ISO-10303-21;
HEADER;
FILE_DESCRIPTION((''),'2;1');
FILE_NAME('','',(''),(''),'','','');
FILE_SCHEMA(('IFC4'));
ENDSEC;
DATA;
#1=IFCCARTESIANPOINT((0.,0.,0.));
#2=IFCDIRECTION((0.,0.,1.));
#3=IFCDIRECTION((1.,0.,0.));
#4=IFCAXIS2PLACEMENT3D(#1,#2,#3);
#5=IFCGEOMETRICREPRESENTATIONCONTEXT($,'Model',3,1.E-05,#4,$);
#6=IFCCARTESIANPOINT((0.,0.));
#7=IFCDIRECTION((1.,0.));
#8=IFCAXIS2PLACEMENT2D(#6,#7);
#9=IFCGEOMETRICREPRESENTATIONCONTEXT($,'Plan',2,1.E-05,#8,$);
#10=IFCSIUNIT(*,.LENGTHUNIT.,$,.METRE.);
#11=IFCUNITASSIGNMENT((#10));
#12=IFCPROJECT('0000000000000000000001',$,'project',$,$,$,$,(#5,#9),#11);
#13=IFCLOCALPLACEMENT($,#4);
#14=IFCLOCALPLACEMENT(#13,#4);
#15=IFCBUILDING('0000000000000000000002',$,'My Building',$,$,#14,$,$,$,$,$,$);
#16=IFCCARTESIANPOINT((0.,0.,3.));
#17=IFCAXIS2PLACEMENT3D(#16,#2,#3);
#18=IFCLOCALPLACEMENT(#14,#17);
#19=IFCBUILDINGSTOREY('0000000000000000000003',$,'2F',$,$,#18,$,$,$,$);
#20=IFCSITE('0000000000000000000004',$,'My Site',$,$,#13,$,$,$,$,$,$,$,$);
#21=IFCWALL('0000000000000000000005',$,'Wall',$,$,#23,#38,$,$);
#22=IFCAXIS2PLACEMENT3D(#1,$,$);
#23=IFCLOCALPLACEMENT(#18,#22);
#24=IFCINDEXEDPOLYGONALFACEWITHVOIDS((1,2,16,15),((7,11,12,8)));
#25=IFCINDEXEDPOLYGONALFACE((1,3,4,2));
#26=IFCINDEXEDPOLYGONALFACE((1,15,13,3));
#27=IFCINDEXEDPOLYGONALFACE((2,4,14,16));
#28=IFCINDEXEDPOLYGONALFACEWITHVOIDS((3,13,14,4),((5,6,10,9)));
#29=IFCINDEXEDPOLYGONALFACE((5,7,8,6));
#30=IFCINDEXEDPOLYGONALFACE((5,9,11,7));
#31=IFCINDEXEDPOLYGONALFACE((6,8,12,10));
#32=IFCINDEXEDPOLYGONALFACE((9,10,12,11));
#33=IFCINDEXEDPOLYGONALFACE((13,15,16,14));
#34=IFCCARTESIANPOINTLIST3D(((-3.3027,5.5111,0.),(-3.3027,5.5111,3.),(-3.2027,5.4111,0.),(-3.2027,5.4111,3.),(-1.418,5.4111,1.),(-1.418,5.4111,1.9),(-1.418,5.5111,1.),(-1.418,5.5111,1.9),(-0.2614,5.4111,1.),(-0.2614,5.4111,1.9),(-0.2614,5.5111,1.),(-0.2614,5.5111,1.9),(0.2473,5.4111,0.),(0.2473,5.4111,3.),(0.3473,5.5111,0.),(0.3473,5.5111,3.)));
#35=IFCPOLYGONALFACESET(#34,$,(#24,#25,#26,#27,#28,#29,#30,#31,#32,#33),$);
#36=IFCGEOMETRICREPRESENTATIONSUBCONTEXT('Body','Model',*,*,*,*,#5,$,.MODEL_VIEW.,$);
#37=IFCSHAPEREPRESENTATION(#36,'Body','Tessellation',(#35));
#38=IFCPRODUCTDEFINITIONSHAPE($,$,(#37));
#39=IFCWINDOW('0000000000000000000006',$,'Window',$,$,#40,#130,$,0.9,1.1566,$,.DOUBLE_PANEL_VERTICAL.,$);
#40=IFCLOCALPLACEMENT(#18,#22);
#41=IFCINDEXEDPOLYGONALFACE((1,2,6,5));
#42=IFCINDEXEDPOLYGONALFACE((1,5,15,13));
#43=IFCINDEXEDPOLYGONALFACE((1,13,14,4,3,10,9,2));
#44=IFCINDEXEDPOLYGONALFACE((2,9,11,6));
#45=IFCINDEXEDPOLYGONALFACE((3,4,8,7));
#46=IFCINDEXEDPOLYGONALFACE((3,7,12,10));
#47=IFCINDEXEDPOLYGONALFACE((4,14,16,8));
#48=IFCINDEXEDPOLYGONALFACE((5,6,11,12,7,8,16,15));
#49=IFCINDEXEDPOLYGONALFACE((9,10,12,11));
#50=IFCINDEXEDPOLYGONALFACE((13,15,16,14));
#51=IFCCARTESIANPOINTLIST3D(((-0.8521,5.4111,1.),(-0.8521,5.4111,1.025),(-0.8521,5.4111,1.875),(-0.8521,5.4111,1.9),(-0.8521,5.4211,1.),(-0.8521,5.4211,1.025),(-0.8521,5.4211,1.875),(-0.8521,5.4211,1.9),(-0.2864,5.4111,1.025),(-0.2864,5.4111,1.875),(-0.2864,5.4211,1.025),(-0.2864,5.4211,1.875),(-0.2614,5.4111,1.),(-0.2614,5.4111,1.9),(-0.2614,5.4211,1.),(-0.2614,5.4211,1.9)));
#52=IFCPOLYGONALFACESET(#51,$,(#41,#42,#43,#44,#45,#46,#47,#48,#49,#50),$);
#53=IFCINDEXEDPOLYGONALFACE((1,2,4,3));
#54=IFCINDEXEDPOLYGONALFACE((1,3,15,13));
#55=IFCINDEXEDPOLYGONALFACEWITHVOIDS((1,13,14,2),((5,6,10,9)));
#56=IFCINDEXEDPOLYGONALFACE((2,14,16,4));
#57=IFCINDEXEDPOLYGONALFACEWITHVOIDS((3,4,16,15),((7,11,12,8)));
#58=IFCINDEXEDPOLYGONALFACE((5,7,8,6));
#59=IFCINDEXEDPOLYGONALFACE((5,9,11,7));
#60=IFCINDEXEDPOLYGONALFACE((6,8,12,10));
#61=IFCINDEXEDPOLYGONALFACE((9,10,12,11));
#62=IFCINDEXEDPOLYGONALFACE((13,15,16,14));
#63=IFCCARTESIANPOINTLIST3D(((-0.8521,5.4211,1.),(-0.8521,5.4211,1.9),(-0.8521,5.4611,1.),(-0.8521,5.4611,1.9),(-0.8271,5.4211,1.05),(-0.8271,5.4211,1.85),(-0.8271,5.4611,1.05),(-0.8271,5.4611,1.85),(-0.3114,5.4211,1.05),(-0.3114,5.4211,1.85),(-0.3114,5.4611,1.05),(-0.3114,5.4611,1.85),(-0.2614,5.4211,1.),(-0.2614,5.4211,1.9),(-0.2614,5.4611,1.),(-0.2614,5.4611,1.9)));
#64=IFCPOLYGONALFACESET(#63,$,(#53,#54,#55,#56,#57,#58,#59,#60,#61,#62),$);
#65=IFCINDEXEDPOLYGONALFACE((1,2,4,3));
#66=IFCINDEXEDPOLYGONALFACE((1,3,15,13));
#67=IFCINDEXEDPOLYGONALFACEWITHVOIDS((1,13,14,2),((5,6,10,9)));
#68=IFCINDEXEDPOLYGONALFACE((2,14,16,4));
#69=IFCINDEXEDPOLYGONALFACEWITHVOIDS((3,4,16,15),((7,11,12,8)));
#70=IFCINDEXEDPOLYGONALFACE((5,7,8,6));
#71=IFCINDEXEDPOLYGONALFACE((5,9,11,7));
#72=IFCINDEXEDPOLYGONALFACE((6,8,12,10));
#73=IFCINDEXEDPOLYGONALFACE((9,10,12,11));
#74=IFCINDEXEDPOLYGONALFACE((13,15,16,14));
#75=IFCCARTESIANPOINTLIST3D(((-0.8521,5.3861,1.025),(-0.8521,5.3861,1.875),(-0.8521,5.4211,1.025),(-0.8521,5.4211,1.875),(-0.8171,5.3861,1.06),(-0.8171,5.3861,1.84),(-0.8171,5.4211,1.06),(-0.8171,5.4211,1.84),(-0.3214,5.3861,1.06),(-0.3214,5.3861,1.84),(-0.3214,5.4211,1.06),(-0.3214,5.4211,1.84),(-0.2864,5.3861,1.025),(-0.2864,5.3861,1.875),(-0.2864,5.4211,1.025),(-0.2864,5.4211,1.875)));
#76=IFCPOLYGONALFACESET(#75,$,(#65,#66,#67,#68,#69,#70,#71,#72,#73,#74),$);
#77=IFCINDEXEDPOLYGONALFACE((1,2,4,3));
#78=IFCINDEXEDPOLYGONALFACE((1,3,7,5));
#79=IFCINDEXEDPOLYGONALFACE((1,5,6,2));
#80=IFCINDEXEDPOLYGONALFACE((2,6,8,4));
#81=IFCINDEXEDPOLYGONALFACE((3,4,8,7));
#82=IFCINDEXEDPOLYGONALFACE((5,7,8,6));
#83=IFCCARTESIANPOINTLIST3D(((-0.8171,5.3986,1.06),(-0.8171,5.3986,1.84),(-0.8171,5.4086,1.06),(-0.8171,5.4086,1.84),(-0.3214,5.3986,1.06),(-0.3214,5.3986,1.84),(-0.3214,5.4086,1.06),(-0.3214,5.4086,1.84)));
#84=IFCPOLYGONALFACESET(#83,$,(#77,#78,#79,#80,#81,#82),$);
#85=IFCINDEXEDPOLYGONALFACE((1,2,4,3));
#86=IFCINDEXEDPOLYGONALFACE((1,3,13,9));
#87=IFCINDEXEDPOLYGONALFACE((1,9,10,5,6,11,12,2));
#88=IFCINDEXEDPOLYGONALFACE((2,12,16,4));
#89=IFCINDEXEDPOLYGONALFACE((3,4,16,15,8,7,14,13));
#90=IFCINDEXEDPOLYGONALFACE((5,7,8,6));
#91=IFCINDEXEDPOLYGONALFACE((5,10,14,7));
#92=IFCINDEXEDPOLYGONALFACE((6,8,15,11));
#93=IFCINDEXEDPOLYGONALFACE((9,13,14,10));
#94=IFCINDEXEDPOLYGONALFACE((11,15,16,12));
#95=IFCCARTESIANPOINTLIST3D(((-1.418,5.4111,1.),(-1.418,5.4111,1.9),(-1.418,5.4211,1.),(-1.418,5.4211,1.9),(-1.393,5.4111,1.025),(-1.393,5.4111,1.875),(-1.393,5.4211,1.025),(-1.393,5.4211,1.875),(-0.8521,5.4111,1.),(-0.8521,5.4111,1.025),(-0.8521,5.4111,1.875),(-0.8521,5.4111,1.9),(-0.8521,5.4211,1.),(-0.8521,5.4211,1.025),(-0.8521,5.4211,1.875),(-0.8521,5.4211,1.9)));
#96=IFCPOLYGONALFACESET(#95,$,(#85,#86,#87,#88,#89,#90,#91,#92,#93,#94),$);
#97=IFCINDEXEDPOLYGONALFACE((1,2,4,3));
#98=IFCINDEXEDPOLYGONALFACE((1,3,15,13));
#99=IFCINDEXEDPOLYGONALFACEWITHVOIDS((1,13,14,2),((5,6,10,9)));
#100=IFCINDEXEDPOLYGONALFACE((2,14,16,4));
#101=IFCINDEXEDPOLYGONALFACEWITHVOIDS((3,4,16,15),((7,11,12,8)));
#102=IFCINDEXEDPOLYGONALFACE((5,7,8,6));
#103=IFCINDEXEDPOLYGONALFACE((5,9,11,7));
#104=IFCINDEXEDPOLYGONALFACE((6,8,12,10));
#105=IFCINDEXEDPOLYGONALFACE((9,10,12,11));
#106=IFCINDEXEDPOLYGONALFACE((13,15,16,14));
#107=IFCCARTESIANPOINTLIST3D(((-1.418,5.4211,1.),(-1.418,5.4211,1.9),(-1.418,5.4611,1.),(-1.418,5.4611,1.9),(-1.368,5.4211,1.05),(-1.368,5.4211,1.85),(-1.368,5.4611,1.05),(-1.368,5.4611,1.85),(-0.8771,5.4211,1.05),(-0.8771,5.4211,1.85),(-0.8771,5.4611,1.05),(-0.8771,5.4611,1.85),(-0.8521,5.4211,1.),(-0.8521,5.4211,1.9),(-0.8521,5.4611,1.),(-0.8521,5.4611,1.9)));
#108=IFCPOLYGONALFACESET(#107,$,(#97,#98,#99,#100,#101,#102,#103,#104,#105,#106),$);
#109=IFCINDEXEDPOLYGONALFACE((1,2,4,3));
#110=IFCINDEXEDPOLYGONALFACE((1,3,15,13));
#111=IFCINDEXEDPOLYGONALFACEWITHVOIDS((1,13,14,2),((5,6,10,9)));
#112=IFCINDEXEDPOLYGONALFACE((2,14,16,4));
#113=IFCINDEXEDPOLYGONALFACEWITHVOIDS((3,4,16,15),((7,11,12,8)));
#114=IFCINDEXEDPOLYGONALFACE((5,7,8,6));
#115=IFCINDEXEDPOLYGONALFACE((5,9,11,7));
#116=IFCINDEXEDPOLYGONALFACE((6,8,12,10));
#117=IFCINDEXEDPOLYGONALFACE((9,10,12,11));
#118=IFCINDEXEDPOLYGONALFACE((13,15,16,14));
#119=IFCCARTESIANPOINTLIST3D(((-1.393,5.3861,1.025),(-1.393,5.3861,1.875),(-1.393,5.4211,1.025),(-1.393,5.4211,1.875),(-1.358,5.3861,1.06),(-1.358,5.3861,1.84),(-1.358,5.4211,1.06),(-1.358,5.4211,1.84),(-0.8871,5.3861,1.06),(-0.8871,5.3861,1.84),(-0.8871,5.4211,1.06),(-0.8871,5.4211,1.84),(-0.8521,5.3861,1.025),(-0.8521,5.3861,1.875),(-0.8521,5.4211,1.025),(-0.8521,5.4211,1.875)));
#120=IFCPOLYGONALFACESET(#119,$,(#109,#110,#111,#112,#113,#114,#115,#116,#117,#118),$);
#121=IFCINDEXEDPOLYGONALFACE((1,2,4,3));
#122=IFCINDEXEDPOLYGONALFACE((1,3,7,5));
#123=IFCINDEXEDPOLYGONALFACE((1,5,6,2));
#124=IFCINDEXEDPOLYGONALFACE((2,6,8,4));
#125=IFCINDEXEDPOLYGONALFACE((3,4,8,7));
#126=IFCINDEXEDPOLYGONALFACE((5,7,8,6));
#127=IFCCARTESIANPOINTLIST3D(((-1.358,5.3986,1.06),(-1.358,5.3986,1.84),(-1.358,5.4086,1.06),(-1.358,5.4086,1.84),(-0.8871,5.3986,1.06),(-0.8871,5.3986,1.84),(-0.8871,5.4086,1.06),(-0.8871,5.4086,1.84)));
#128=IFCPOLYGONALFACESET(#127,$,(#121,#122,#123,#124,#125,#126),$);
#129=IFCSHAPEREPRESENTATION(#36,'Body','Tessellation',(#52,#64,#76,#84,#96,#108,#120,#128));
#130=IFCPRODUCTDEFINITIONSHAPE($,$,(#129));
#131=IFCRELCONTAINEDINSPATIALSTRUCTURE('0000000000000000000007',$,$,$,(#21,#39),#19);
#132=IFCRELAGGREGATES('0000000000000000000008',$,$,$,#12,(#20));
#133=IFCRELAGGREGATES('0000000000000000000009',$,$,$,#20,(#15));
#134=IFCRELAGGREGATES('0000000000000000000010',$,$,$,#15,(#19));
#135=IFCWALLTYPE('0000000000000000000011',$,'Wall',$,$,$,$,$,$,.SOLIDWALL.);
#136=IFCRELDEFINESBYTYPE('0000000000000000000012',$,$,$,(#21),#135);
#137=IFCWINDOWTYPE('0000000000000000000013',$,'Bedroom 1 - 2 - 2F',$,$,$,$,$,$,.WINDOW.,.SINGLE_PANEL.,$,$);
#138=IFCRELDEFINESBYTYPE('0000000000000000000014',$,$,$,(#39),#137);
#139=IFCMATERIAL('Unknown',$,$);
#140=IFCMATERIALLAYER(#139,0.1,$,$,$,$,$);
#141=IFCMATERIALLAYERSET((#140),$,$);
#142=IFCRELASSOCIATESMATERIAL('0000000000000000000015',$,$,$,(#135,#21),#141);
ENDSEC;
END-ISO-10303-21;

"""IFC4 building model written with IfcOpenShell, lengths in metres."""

from ifc_helpers import new_model, entity, si_unit, frame, origin_with_axes, origin_2d_with_axis, place, context, subcontext, project, spatial, line, indexed_curve, outline, extrude, shape, source, transform, mapped, material, layer, layer_set, layer_usage, type_object, type_shapes, element, fill, save


model = new_model("IFC4")

# Units and contexts
model_context = context("Model", 3, precision=1e-05, world=origin_with_axes())
plan_context = context("Plan", 2, precision=1e-05, world=origin_2d_with_axis())
body_context_1 = subcontext(model_context, "Body", "Model", "MODEL_VIEW")
body_context_2 = subcontext(plan_context, "Body", "Plan", "PLAN_VIEW")
ifc_project = project(units=[si_unit("LENGTHUNIT", "METRE")], contexts=[model_context, plan_context])

# Site, building, storey
site_placement = place(None, origin_with_axes())
site = spatial("IfcSite", under=ifc_project, at=site_placement, Name="My Site")
building_placement = place(site_placement, origin_with_axes())
building = spatial("IfcBuilding", under=site, at=building_placement, Name="My Building")
storey_placement = place(building_placement, frame((0.0, 0.0, 3.0), z_axis=(0.0, 0.0, 1.0), x_axis=(1.0, 0.0, 0.0)))
storey = spatial("IfcBuildingStorey", under=building, at=storey_placement, Name="2F")

# Shared definitions
ifc_material = material(Name="Unknown")

# Shared definitions
ifc_layer_1 = layer(ifc_material, 0.1)
ifc_layer_set_1 = layer_set([ifc_layer_1])
wall_type = type_object("IfcWallType", Name="Wall", PredefinedType="SOLIDWALL", material=ifc_layer_set_1)

# Wall, opening, window
ifc_layer_usage_1 = layer_usage(ifc_layer_set_1, "AXIS2", "POSITIVE", 0.0)
wall_1_placement = place(storey_placement, frame((0.3473, 5.5111, 0.0), z_axis=(0.0, 0.0, 1.0), x_axis=(-1.0, 0.0, 0.0)))
wall_1 = element("IfcWall", 1, at=wall_1_placement, inside=storey, type_object=wall_type, material=ifc_layer_usage_1, Name="Wall", context=body_context_1, shape_type="SweptSolid", body=[
    extrude(outline(indexed_curve([(0.0, 0.0), (0.1, 0.1), (3.55, 0.1), (3.65, 0.0)], segments=[line(1, 2, 3, 4, 1)])), origin_with_axes(), (0.0, 0.0, 1.0), 3.0),
])
shared_shape_1 = source(origin_with_axes(), body_context_1, "Body", "SweptSolid", [
    extrude(outline(indexed_curve([(0.0, 0.0), (1.1566, 0.0), (1.1566, 0.9), (0.0, 0.9)], segments=[line(1, 2, 3, 4, 1)])), frame((0.0, -0.6, 0.0), z_axis=(0.0, -1.0, 0.0), x_axis=(1.0, 0.0, 0.0)), (0.0, 0.0, -1.0), 1.2),
])
opening_1_placement = place(wall_1_placement, frame((0.6086, 0.0, 1.0), z_axis=(0.0, 0.0, 1.0), x_axis=(1.0, 0.0, 0.0)))
opening_1 = element("IfcOpeningElement", 2, at=opening_1_placement, cuts=wall_1, PredefinedType="OPENING", context=body_context_1, shape_type="MappedRepresentation", body=[
    mapped(shared_shape_1, transform((0.0, 0.0, 0.0), x_axis=(1.0, 0.0, 0.0), y_axis=(0.0, 1.0, 0.0), z_axis=(0.0, 0.0, 1.0), scale=1.0)),
])
window_type_1 = type_object("IfcWindowType", Name="Bedroom 1 - 2 - 2F", PartitioningType="SINGLE_PANEL", PredefinedType="WINDOW")
shared_shape_2 = source(origin_with_axes(), body_context_1, "Body", "SweptSolid", [
    extrude(outline(indexed_curve([(0.5908, 0.0), (0.0, 0.0), (0.0, 0.9), (0.5908, 0.9), (0.5908, 0.875), (0.025, 0.875), (0.025, 0.025), (0.5908, 0.025)], segments=[line(1, 2, 3, 4, 5, 6, 7, 8, 1)])), frame((0.0, 0.09, 0.0), z_axis=(0.0, -1.0, 0.0), x_axis=(1.0, 0.0, 0.0)), (0.0, 0.0, -1.0), 0.01),
    extrude(outline(indexed_curve([(0.0, 0.0), (0.5908, 0.0), (0.5908, 0.9), (0.0, 0.9)], segments=[line(1, 2, 3, 4, 1)]), holes=[indexed_curve([(0.05, 0.05), (0.5658, 0.05), (0.5658, 0.85), (0.05, 0.85)], segments=[line(1, 2, 3, 4, 1)])]), frame((0.0, 0.05, 0.0), z_axis=(0.0, -1.0, 0.0), x_axis=(1.0, 0.0, 0.0)), (0.0, 0.0, -1.0), 0.04),
    extrude(outline(indexed_curve([(0.0, 0.0), (0.5658, 0.0), (0.5658, 0.85), (0.0, 0.85)], segments=[line(1, 2, 3, 4, 1)]), holes=[indexed_curve([(0.035, 0.035), (0.5308, 0.035), (0.5308, 0.815), (0.035, 0.815)], segments=[line(1, 2, 3, 4, 1)])]), frame((0.025, 0.09, 0.025), z_axis=(0.0, -1.0, 0.0), x_axis=(1.0, 0.0, 0.0)), (0.0, 0.0, -1.0), 0.035),
    extrude(outline(indexed_curve([(0.035, 0.035), (0.5308, 0.035), (0.5308, 0.815), (0.035, 0.815)], segments=[line(1, 2, 3, 4, 1)])), frame((0.025, 0.1025, 0.025), z_axis=(0.0, -1.0, 0.0), x_axis=(1.0, 0.0, 0.0)), (0.0, 0.0, -1.0), 0.01),
    extrude(outline(indexed_curve([(0.0, 0.9), (0.5659, 0.9), (0.5659, 0.0), (0.0, 0.0), (0.0, 0.025), (0.5409, 0.025), (0.5409, 0.875), (0.0, 0.875)], segments=[line(1, 2, 3, 4, 5, 6, 7, 8, 1)])), frame((0.5908, 0.09, 0.0), z_axis=(0.0, -1.0, 0.0), x_axis=(1.0, 0.0, 0.0)), (0.0, 0.0, -1.0), 0.01),
    extrude(outline(indexed_curve([(0.0, 0.0), (0.5659, 0.0), (0.5659, 0.9), (0.0, 0.9)], segments=[line(1, 2, 3, 4, 1)]), holes=[indexed_curve([(0.025, 0.05), (0.5159, 0.05), (0.5159, 0.85), (0.025, 0.85)], segments=[line(1, 2, 3, 4, 1)])]), frame((0.5908, 0.05, 0.0), z_axis=(0.0, -1.0, 0.0), x_axis=(1.0, 0.0, 0.0)), (0.0, 0.0, -1.0), 0.04),
    extrude(outline(indexed_curve([(0.0, 0.0), (0.5409, 0.0), (0.5409, 0.85), (0.0, 0.85)], segments=[line(1, 2, 3, 4, 1)]), holes=[indexed_curve([(0.035, 0.035), (0.5059, 0.035), (0.5059, 0.815), (0.035, 0.815)], segments=[line(1, 2, 3, 4, 1)])]), frame((0.5908, 0.09, 0.025), z_axis=(0.0, -1.0, 0.0), x_axis=(1.0, 0.0, 0.0)), (0.0, 0.0, -1.0), 0.035),
    extrude(outline(indexed_curve([(0.035, 0.035), (0.5059, 0.035), (0.5059, 0.815), (0.035, 0.815)], segments=[line(1, 2, 3, 4, 1)])), frame((0.5908, 0.1025, 0.025), z_axis=(0.0, -1.0, 0.0), x_axis=(1.0, 0.0, 0.0)), (0.0, 0.0, -1.0), 0.01),
])
shared_shape_3 = source(origin_with_axes(), body_context_2, "Body", "Curve2D", [
    entity("IfcIndexedPolyCurve", entity("IfcCartesianPointList2D", [[0.05, 0.05], [0.5658, 0.05]])),
    entity("IfcIndexedPolyCurve", entity("IfcCartesianPointList2D", [[0.0, 0.1], [0.025, 0.1], [0.025, 0.09], [0.05, 0.09], [0.05, 0.05], [0.0, 0.05]]), [entity("IfcLineIndex", [1, 2, 3, 4, 5, 6, 1])]),
    entity("IfcIndexedPolyCurve", entity("IfcCartesianPointList2D", [[0.5908, 0.1], [0.5908, 0.1], [0.5908, 0.09], [0.5658, 0.09], [0.5658, 0.05], [0.5908, 0.05]])),
    entity("IfcIndexedPolyCurve", entity("IfcCartesianPointList2D", [[0.025, 0.09], [0.06, 0.09], [0.06, 0.125], [0.025, 0.125]]), [entity("IfcLineIndex", [1, 2, 3, 4, 1])]),
    entity("IfcIndexedPolyCurve", entity("IfcCartesianPointList2D", [[0.5908, 0.09], [0.5558, 0.09], [0.5558, 0.125], [0.5908, 0.125]]), [entity("IfcLineIndex", [1, 2, 3, 4, 1])]),
    entity("IfcIndexedPolyCurve", entity("IfcCartesianPointList2D", [[0.06, 0.09], [0.5558, 0.09]])),
    entity("IfcIndexedPolyCurve", entity("IfcCartesianPointList2D", [[0.06, 0.125], [0.5558, 0.125]])),
    entity("IfcIndexedPolyCurve", entity("IfcCartesianPointList2D", [[0.06, 0.1075], [0.5558, 0.1075]])),
    entity("IfcIndexedPolyCurve", entity("IfcCartesianPointList2D", [[0.6158, 0.05], [1.1066, 0.05]])),
    entity("IfcIndexedPolyCurve", entity("IfcCartesianPointList2D", [[0.5908, 0.1], [0.5908, 0.1], [0.5908, 0.09], [0.6158, 0.09], [0.6158, 0.05], [0.5908, 0.05]])),
    entity("IfcIndexedPolyCurve", entity("IfcCartesianPointList2D", [[1.1566, 0.1], [1.1316, 0.1], [1.1316, 0.09], [1.1066, 0.09], [1.1066, 0.05], [1.1566, 0.05]]), [entity("IfcLineIndex", [1, 2, 3, 4, 5, 6, 1])]),
    entity("IfcIndexedPolyCurve", entity("IfcCartesianPointList2D", [[0.5908, 0.09], [0.6258, 0.09], [0.6258, 0.125], [0.5908, 0.125]]), [entity("IfcLineIndex", [1, 2, 3, 4, 1])]),
    entity("IfcIndexedPolyCurve", entity("IfcCartesianPointList2D", [[1.1316, 0.09], [1.0966, 0.09], [1.0966, 0.125], [1.1316, 0.125]]), [entity("IfcLineIndex", [1, 2, 3, 4, 1])]),
    entity("IfcIndexedPolyCurve", entity("IfcCartesianPointList2D", [[0.6258, 0.09], [1.0966, 0.09]])),
    entity("IfcIndexedPolyCurve", entity("IfcCartesianPointList2D", [[0.6258, 0.125], [1.0966, 0.125]])),
    entity("IfcIndexedPolyCurve", entity("IfcCartesianPointList2D", [[0.6258, 0.1075], [1.0966, 0.1075]])),
])
type_shapes(window_type_1, [shared_shape_2, shared_shape_3])
window_1_placement = place(opening_1_placement, frame((0.0, 0.0, 0.0), z_axis=(0.0, 0.0, 1.0), x_axis=(1.0, 0.0, 0.0)))
window_1 = element("IfcWindow", 3, at=window_1_placement, inside=storey, type_object=window_type_1, Name="Window", OverallHeight=0.9, OverallWidth=1.1566, PartitioningType="DOUBLE_PANEL_VERTICAL", shapes=[
    shape(body_context_1, "Body", "MappedRepresentation", [mapped(shared_shape_2, transform((0.0, 0.0, 0.0), x_axis=(1.0, 0.0, 0.0), y_axis=(0.0, 1.0, 0.0), z_axis=(0.0, 0.0, 1.0), scale=1.0))]),
    shape(body_context_2, "Body", "MappedRepresentation", [mapped(shared_shape_3, transform((0.0, 0.0, 0.0), x_axis=(1.0, 0.0, 0.0), y_axis=(0.0, 1.0, 0.0), z_axis=(0.0, 0.0, 1.0), scale=1.0))]),
])
fill(opening_1, window_1)

save(model, "model.ifc")
